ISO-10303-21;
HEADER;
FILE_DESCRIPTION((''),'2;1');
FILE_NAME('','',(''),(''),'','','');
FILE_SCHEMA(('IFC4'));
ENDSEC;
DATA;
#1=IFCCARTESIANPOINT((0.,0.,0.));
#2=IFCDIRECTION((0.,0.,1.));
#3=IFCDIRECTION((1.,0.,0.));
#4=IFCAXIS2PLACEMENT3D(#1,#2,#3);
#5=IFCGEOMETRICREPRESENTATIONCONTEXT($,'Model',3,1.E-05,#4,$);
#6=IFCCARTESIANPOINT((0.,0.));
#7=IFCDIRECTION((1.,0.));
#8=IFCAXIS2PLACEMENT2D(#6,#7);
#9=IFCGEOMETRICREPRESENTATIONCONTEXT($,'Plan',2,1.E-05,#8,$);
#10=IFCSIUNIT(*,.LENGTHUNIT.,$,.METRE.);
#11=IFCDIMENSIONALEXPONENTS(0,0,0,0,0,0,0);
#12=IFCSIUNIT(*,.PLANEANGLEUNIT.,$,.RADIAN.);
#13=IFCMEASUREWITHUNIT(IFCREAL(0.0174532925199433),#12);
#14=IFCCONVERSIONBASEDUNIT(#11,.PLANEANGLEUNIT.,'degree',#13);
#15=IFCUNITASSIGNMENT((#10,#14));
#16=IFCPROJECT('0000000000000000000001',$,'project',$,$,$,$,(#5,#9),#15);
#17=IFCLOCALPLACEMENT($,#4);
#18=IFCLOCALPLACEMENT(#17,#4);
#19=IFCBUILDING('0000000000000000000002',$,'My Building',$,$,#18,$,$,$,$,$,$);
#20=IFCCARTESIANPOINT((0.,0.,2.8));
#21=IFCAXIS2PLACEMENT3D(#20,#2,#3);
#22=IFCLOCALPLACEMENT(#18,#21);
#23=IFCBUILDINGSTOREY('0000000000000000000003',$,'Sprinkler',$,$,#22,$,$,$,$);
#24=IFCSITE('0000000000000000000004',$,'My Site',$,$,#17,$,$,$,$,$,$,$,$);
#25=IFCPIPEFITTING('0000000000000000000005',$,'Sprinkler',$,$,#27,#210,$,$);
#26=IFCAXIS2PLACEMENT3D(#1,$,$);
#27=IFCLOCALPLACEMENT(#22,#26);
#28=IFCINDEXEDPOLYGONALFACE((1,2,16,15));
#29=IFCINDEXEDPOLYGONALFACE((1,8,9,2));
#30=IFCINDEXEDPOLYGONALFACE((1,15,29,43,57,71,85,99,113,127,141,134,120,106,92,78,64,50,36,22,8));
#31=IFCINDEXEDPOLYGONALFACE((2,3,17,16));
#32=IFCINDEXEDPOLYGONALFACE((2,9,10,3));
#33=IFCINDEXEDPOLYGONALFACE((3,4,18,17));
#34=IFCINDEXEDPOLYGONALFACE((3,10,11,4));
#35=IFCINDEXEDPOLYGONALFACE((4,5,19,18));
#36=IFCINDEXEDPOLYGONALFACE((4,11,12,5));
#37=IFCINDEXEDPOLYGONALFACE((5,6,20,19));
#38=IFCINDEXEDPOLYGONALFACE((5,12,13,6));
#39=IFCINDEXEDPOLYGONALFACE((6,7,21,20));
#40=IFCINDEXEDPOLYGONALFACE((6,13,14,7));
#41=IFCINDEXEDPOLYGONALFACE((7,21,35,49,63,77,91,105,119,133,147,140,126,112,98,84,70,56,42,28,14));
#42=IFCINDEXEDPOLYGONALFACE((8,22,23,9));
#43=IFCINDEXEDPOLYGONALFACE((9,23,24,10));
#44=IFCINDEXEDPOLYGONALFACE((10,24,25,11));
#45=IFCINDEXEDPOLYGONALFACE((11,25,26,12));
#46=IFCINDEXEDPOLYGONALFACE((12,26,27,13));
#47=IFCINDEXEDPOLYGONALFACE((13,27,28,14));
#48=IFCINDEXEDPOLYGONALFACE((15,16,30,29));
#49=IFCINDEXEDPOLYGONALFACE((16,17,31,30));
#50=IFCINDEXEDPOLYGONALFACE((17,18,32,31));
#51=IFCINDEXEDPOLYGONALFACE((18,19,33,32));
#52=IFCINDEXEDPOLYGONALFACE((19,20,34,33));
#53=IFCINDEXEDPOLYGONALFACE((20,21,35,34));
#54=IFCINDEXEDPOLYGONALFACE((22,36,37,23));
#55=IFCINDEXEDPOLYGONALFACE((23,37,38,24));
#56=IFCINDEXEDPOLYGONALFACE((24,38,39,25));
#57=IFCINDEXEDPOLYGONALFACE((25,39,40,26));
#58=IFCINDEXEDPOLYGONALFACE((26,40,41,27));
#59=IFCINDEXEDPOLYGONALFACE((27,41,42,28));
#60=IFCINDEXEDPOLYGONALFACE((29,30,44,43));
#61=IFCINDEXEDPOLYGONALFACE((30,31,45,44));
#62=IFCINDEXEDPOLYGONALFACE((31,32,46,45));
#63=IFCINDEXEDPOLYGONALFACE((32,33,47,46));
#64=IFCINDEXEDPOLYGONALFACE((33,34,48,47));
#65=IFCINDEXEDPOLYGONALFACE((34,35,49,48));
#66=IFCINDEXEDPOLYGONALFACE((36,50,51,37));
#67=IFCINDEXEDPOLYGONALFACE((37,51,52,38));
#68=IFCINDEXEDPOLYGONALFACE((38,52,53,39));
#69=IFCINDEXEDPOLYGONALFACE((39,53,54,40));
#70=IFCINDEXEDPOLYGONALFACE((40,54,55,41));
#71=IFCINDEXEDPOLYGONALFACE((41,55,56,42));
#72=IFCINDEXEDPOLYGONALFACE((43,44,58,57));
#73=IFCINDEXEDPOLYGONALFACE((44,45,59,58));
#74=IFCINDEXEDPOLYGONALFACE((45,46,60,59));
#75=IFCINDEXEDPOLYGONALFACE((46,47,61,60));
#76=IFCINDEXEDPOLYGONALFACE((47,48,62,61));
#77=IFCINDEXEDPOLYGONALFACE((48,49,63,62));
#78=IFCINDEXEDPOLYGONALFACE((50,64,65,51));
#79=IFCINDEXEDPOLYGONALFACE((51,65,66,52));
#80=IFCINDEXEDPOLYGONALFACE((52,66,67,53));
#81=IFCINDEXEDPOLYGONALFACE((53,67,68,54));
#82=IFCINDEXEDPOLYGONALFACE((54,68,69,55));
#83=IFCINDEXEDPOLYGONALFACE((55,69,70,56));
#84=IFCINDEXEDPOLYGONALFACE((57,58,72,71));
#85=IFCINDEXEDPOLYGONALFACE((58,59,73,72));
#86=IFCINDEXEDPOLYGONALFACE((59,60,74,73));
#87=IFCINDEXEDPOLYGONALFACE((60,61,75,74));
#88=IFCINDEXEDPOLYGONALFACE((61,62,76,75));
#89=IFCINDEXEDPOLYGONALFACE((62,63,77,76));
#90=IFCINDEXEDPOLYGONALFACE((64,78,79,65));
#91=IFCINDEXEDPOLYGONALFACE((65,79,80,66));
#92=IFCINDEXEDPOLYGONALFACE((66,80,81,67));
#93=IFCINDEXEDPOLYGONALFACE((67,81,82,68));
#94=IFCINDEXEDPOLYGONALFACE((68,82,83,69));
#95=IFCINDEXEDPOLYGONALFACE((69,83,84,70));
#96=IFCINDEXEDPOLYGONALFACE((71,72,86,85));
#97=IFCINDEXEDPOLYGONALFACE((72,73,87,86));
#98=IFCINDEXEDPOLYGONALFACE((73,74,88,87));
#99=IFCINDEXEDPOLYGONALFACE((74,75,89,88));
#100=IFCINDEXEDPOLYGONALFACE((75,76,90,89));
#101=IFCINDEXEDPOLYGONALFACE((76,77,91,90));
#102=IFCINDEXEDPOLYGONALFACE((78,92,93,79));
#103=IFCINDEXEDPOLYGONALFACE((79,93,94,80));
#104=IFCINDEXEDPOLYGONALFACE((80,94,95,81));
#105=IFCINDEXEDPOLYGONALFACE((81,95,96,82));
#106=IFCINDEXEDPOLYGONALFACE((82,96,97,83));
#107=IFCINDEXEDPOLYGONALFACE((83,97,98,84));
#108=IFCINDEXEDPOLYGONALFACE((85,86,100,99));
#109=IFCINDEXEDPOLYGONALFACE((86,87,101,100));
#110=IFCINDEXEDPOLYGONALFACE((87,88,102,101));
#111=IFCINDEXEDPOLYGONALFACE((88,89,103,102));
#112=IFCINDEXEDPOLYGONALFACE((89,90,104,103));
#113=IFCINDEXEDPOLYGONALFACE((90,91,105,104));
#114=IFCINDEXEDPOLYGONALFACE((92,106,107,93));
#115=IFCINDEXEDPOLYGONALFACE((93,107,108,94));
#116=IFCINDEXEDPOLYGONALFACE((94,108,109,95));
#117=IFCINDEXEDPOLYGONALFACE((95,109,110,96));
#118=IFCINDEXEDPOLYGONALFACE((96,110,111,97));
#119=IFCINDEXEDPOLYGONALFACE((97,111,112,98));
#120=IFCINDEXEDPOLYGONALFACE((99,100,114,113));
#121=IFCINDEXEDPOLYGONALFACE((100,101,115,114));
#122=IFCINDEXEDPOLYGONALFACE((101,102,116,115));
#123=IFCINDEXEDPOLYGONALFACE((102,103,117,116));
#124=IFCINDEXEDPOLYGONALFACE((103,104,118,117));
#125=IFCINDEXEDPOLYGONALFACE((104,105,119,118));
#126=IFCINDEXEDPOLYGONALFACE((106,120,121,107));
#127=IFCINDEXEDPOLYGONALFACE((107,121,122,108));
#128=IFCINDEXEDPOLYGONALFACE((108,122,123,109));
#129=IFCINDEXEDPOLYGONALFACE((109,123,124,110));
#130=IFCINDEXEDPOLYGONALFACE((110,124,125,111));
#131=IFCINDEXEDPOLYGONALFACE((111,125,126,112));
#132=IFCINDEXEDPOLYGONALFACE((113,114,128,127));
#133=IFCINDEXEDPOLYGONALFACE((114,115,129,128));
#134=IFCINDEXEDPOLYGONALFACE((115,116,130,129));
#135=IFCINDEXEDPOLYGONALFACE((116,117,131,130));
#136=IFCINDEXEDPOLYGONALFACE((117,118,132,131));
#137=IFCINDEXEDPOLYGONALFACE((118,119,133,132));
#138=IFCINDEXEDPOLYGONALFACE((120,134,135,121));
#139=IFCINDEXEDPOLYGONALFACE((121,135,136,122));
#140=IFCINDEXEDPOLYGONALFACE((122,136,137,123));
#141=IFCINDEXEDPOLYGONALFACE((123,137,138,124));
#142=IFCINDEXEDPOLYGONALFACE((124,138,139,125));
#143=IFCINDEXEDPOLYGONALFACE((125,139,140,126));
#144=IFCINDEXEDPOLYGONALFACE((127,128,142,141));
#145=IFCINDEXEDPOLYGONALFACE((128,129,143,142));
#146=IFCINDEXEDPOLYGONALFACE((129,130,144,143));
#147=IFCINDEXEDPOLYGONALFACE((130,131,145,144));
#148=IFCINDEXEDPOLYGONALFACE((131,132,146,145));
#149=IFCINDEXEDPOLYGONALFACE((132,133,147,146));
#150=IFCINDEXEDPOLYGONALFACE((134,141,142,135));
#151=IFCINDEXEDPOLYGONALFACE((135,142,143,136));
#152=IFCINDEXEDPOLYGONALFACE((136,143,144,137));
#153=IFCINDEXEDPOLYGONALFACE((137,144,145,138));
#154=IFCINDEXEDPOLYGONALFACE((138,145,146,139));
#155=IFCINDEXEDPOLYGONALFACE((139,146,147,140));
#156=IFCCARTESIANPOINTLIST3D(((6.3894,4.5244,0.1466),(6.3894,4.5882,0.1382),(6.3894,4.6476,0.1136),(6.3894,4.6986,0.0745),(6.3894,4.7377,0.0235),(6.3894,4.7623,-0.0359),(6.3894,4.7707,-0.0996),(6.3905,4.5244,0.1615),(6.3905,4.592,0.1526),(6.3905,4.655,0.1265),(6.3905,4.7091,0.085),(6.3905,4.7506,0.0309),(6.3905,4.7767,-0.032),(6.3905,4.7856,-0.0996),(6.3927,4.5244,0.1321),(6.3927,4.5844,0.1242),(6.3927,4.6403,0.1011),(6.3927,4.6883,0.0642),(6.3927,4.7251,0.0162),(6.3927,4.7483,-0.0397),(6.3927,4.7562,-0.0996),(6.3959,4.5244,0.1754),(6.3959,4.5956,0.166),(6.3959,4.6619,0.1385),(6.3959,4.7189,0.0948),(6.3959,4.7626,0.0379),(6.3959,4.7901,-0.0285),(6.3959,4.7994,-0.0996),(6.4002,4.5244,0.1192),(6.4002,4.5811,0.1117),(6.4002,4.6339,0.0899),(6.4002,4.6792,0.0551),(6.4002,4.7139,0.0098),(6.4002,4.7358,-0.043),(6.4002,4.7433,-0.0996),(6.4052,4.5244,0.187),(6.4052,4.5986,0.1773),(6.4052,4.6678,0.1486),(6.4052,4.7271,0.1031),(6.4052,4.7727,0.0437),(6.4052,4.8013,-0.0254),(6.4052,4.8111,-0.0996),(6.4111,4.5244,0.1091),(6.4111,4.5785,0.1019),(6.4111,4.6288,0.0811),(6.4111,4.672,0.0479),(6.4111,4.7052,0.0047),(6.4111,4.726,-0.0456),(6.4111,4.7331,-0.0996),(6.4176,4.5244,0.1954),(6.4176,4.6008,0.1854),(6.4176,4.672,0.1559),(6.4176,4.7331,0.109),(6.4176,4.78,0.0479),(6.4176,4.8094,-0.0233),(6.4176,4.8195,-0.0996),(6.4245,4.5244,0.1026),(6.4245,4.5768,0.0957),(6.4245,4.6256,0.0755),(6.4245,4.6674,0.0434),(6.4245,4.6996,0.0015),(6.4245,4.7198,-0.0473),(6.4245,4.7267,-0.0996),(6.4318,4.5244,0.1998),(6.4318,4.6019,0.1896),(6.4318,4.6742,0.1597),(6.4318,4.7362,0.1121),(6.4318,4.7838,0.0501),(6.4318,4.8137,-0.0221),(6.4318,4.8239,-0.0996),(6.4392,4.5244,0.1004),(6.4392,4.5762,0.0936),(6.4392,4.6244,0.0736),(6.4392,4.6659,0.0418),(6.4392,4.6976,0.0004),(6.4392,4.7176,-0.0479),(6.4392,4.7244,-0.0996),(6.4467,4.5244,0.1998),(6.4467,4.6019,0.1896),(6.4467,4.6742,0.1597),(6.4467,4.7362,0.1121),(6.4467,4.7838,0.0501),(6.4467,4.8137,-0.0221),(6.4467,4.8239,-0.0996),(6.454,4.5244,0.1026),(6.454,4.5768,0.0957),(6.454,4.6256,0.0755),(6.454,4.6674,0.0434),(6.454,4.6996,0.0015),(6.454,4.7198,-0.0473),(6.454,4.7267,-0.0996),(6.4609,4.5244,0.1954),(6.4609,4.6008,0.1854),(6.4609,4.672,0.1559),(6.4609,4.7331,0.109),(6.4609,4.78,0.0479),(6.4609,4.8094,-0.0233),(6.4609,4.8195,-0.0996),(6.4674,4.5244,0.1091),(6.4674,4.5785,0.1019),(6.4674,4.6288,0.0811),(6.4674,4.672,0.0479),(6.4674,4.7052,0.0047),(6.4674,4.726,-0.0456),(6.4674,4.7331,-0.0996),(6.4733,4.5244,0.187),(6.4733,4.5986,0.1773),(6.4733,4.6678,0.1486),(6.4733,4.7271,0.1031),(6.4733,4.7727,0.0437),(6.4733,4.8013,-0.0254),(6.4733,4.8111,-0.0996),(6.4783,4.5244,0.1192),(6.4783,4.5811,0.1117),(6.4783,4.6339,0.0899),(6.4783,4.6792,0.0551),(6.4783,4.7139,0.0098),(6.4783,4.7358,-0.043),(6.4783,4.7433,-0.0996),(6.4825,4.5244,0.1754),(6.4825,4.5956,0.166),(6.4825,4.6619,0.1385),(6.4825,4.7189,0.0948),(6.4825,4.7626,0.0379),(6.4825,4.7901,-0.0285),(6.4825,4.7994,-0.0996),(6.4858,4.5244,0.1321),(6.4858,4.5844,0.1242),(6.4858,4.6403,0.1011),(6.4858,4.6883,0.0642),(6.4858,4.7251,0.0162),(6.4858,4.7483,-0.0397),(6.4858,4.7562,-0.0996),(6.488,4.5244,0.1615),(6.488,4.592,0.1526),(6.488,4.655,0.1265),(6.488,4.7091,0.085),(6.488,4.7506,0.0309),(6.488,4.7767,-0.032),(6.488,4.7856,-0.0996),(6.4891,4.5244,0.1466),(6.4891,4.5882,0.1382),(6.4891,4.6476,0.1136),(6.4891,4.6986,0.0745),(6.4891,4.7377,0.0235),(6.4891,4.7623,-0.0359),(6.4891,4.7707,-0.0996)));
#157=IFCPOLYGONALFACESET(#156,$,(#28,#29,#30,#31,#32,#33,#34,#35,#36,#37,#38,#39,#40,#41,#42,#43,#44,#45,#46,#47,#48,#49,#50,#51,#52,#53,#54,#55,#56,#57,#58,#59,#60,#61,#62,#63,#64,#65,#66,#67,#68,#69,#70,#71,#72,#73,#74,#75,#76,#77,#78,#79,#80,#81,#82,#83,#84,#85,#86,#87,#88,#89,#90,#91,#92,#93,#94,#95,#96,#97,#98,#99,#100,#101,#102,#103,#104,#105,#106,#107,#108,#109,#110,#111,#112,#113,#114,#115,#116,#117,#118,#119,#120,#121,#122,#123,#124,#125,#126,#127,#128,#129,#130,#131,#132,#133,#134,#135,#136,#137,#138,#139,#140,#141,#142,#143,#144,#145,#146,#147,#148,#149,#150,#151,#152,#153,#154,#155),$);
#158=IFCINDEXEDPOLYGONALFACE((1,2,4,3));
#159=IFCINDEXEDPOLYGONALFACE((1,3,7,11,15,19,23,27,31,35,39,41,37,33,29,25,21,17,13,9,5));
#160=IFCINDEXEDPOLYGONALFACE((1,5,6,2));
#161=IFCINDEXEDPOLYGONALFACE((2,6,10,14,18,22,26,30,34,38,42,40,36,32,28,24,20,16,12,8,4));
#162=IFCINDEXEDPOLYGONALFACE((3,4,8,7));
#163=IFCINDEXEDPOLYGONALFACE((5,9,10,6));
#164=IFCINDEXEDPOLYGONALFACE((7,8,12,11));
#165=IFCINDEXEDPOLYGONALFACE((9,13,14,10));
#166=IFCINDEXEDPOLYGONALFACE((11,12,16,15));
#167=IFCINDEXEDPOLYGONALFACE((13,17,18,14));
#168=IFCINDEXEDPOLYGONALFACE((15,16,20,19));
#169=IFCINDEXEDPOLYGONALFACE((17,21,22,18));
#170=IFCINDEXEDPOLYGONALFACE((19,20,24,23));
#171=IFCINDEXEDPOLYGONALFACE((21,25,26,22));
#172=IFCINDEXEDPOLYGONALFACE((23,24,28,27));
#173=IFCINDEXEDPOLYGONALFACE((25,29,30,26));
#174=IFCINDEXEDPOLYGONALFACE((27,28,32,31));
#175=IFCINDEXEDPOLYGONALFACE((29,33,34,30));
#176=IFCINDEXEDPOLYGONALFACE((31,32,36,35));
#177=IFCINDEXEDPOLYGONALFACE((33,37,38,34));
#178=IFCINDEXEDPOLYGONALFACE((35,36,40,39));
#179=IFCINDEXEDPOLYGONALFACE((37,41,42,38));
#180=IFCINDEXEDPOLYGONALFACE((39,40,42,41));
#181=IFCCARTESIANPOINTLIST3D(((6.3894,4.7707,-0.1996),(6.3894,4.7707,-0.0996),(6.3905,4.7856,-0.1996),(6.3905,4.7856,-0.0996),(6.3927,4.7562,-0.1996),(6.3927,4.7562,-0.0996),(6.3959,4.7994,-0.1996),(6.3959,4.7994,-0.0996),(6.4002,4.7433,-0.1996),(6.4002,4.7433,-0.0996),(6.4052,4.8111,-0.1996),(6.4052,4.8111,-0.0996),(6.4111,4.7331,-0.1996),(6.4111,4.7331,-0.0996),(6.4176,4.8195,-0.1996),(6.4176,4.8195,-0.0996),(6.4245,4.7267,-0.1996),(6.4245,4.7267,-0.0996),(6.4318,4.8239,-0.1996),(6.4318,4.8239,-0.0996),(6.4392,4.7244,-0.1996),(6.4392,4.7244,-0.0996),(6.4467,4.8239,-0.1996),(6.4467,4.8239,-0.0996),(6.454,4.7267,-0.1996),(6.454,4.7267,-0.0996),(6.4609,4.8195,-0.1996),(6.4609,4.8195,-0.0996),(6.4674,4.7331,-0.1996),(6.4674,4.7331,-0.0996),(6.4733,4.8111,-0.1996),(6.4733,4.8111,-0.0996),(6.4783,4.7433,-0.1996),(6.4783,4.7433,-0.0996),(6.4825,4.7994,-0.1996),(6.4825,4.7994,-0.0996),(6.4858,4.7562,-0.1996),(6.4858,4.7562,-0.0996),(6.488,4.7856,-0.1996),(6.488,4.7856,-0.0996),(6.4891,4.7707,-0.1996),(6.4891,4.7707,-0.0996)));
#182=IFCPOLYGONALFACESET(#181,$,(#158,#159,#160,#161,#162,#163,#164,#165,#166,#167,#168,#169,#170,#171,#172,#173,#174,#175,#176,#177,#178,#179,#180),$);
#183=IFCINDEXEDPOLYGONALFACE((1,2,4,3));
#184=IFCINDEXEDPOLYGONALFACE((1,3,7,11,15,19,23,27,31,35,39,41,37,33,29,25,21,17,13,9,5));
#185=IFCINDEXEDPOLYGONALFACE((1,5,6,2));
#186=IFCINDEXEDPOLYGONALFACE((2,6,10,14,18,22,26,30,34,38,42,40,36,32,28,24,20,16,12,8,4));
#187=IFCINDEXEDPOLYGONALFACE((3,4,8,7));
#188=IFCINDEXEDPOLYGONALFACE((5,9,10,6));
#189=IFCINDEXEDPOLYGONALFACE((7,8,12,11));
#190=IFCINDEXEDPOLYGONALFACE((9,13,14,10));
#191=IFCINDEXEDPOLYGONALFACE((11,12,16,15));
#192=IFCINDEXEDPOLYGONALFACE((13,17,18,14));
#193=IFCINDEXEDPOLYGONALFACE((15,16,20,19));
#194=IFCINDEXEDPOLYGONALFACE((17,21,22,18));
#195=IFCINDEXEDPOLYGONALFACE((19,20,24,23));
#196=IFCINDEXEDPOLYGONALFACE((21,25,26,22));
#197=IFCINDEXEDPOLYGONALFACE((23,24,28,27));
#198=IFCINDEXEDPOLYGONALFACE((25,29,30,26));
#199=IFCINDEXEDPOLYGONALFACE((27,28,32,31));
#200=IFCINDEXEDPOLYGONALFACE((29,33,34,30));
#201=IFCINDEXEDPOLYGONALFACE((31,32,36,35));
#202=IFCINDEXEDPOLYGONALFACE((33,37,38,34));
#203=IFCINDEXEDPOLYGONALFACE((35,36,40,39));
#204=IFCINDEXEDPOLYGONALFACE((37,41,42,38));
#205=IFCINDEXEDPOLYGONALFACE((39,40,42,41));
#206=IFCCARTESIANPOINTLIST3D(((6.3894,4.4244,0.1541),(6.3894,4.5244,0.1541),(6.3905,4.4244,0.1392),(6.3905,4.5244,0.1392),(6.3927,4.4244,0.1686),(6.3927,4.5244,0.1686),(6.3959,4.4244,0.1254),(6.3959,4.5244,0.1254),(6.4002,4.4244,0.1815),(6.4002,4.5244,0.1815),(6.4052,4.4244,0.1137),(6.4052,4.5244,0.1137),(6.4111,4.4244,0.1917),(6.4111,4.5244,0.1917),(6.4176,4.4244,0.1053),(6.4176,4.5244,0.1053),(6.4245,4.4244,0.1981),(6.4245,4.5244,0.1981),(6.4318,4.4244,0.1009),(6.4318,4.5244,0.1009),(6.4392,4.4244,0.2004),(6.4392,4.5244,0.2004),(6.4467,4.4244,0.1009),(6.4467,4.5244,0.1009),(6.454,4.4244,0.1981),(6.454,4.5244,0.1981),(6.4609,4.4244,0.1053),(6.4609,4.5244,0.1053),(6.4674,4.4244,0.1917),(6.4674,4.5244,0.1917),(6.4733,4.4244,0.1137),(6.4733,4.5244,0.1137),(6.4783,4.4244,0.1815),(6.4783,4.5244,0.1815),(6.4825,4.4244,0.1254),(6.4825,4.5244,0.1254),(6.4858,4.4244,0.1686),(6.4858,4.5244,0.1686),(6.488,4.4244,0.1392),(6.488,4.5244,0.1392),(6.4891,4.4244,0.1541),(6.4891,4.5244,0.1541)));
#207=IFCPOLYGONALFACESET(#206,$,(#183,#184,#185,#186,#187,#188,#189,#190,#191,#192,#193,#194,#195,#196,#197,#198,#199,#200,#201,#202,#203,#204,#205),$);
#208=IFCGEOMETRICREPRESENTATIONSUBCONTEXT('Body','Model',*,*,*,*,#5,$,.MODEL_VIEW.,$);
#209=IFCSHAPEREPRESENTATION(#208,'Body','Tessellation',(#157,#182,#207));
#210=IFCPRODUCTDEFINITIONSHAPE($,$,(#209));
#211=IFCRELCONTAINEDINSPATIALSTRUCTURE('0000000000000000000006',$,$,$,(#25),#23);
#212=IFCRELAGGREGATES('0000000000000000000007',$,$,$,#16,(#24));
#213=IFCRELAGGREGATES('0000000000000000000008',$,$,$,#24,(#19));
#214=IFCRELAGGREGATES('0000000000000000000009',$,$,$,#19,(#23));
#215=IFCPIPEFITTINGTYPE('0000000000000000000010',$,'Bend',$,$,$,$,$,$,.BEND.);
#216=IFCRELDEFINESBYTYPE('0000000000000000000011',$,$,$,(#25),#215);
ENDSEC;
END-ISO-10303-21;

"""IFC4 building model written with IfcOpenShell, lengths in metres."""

from ifc_helpers import new_model, entity, si_unit, converted_unit, frame, origin_with_axes, origin_2d_with_axis, place, context, subcontext, project, spatial, circle, extrude, source, transform, mapped, type_object, type_shapes, element, save


model = new_model("IFC4")

# Units and contexts
model_context = context("Model", 3, precision=1e-05, world=origin_with_axes())
plan_context = context("Plan", 2, precision=1e-05, world=origin_2d_with_axis())
body_context = subcontext(model_context, "Body", "Model", "MODEL_VIEW")
ifc_project = project(units=[si_unit("LENGTHUNIT", "METRE"), converted_unit("PLANEANGLEUNIT", "degree", entity("IfcReal", 0.0174532925199433), si_unit("PLANEANGLEUNIT", "RADIAN"), dimensions=[0, 0, 0, 0, 0, 0, 0])], contexts=[model_context, plan_context])

# Site, building, storey
site_placement = place(None, origin_with_axes())
site = spatial("IfcSite", under=ifc_project, at=site_placement, Name="My Site")
building_placement = place(site_placement, origin_with_axes())
building = spatial("IfcBuilding", under=site, at=building_placement, Name="My Building")
storey_placement = place(building_placement, frame((0.0, 0.0, 2.8), z_axis=(0.0, 0.0, 1.0), x_axis=(1.0, 0.0, 0.0)))
storey = spatial("IfcBuildingStorey", under=building, at=storey_placement, Name="Sprinkler")

# Pipe fitting
pipe_fitting_type_1 = type_object("IfcPipeFittingType", Name="Bend", PredefinedType="BEND")
shared_shape = source(origin_with_axes(), body_context, "Body", "SolidModel", [
    entity("IfcSweptDiskSolid", entity("IfcIndexedPolyCurve", entity("IfcCartesianPointList3D", [[0.0, 0.0, 0.1], [0.0732, 0.0, 0.2768], [0.25, 0.0, 0.35]]), [entity("IfcArcIndex", [1, 2, 3])]), 0.05),
    extrude(circle(Radius=0.05), origin_with_axes(), (0.0, 0.0, 1.0), 0.1),
    extrude(circle(Radius=0.05), frame((0.25, 0.0, 0.35), z_axis=(1.0, 0.0, 0.000001), x_axis=(-0.000001, 0.0, 1.0)), (0.0, 0.0, 1.0), 0.1),
])
type_shapes(pipe_fitting_type_1, [shared_shape])
for number, where, z_axis, x_axis, name in (
    (1, (6.4392, 4.7744, -0.1996), (0.0, -0.000008, 1.0), (0.0, -1.0, -0.000008), "Sprinkler"),
):
    element("IfcPipeFitting", number, at=place(storey_placement, frame(where, z_axis=z_axis, x_axis=x_axis)), inside=storey, type_object=pipe_fitting_type_1, Name=name, context=body_context, shape_type="MappedRepresentation", body=[
        mapped(shared_shape, transform((0.0, 0.0, 0.0), x_axis=(1.0, 0.0, 0.0), y_axis=(0.0, 1.0, 0.0), z_axis=(0.0, 0.0, 1.0), scale=1.0)),
    ])

save(model, "model.ifc")
